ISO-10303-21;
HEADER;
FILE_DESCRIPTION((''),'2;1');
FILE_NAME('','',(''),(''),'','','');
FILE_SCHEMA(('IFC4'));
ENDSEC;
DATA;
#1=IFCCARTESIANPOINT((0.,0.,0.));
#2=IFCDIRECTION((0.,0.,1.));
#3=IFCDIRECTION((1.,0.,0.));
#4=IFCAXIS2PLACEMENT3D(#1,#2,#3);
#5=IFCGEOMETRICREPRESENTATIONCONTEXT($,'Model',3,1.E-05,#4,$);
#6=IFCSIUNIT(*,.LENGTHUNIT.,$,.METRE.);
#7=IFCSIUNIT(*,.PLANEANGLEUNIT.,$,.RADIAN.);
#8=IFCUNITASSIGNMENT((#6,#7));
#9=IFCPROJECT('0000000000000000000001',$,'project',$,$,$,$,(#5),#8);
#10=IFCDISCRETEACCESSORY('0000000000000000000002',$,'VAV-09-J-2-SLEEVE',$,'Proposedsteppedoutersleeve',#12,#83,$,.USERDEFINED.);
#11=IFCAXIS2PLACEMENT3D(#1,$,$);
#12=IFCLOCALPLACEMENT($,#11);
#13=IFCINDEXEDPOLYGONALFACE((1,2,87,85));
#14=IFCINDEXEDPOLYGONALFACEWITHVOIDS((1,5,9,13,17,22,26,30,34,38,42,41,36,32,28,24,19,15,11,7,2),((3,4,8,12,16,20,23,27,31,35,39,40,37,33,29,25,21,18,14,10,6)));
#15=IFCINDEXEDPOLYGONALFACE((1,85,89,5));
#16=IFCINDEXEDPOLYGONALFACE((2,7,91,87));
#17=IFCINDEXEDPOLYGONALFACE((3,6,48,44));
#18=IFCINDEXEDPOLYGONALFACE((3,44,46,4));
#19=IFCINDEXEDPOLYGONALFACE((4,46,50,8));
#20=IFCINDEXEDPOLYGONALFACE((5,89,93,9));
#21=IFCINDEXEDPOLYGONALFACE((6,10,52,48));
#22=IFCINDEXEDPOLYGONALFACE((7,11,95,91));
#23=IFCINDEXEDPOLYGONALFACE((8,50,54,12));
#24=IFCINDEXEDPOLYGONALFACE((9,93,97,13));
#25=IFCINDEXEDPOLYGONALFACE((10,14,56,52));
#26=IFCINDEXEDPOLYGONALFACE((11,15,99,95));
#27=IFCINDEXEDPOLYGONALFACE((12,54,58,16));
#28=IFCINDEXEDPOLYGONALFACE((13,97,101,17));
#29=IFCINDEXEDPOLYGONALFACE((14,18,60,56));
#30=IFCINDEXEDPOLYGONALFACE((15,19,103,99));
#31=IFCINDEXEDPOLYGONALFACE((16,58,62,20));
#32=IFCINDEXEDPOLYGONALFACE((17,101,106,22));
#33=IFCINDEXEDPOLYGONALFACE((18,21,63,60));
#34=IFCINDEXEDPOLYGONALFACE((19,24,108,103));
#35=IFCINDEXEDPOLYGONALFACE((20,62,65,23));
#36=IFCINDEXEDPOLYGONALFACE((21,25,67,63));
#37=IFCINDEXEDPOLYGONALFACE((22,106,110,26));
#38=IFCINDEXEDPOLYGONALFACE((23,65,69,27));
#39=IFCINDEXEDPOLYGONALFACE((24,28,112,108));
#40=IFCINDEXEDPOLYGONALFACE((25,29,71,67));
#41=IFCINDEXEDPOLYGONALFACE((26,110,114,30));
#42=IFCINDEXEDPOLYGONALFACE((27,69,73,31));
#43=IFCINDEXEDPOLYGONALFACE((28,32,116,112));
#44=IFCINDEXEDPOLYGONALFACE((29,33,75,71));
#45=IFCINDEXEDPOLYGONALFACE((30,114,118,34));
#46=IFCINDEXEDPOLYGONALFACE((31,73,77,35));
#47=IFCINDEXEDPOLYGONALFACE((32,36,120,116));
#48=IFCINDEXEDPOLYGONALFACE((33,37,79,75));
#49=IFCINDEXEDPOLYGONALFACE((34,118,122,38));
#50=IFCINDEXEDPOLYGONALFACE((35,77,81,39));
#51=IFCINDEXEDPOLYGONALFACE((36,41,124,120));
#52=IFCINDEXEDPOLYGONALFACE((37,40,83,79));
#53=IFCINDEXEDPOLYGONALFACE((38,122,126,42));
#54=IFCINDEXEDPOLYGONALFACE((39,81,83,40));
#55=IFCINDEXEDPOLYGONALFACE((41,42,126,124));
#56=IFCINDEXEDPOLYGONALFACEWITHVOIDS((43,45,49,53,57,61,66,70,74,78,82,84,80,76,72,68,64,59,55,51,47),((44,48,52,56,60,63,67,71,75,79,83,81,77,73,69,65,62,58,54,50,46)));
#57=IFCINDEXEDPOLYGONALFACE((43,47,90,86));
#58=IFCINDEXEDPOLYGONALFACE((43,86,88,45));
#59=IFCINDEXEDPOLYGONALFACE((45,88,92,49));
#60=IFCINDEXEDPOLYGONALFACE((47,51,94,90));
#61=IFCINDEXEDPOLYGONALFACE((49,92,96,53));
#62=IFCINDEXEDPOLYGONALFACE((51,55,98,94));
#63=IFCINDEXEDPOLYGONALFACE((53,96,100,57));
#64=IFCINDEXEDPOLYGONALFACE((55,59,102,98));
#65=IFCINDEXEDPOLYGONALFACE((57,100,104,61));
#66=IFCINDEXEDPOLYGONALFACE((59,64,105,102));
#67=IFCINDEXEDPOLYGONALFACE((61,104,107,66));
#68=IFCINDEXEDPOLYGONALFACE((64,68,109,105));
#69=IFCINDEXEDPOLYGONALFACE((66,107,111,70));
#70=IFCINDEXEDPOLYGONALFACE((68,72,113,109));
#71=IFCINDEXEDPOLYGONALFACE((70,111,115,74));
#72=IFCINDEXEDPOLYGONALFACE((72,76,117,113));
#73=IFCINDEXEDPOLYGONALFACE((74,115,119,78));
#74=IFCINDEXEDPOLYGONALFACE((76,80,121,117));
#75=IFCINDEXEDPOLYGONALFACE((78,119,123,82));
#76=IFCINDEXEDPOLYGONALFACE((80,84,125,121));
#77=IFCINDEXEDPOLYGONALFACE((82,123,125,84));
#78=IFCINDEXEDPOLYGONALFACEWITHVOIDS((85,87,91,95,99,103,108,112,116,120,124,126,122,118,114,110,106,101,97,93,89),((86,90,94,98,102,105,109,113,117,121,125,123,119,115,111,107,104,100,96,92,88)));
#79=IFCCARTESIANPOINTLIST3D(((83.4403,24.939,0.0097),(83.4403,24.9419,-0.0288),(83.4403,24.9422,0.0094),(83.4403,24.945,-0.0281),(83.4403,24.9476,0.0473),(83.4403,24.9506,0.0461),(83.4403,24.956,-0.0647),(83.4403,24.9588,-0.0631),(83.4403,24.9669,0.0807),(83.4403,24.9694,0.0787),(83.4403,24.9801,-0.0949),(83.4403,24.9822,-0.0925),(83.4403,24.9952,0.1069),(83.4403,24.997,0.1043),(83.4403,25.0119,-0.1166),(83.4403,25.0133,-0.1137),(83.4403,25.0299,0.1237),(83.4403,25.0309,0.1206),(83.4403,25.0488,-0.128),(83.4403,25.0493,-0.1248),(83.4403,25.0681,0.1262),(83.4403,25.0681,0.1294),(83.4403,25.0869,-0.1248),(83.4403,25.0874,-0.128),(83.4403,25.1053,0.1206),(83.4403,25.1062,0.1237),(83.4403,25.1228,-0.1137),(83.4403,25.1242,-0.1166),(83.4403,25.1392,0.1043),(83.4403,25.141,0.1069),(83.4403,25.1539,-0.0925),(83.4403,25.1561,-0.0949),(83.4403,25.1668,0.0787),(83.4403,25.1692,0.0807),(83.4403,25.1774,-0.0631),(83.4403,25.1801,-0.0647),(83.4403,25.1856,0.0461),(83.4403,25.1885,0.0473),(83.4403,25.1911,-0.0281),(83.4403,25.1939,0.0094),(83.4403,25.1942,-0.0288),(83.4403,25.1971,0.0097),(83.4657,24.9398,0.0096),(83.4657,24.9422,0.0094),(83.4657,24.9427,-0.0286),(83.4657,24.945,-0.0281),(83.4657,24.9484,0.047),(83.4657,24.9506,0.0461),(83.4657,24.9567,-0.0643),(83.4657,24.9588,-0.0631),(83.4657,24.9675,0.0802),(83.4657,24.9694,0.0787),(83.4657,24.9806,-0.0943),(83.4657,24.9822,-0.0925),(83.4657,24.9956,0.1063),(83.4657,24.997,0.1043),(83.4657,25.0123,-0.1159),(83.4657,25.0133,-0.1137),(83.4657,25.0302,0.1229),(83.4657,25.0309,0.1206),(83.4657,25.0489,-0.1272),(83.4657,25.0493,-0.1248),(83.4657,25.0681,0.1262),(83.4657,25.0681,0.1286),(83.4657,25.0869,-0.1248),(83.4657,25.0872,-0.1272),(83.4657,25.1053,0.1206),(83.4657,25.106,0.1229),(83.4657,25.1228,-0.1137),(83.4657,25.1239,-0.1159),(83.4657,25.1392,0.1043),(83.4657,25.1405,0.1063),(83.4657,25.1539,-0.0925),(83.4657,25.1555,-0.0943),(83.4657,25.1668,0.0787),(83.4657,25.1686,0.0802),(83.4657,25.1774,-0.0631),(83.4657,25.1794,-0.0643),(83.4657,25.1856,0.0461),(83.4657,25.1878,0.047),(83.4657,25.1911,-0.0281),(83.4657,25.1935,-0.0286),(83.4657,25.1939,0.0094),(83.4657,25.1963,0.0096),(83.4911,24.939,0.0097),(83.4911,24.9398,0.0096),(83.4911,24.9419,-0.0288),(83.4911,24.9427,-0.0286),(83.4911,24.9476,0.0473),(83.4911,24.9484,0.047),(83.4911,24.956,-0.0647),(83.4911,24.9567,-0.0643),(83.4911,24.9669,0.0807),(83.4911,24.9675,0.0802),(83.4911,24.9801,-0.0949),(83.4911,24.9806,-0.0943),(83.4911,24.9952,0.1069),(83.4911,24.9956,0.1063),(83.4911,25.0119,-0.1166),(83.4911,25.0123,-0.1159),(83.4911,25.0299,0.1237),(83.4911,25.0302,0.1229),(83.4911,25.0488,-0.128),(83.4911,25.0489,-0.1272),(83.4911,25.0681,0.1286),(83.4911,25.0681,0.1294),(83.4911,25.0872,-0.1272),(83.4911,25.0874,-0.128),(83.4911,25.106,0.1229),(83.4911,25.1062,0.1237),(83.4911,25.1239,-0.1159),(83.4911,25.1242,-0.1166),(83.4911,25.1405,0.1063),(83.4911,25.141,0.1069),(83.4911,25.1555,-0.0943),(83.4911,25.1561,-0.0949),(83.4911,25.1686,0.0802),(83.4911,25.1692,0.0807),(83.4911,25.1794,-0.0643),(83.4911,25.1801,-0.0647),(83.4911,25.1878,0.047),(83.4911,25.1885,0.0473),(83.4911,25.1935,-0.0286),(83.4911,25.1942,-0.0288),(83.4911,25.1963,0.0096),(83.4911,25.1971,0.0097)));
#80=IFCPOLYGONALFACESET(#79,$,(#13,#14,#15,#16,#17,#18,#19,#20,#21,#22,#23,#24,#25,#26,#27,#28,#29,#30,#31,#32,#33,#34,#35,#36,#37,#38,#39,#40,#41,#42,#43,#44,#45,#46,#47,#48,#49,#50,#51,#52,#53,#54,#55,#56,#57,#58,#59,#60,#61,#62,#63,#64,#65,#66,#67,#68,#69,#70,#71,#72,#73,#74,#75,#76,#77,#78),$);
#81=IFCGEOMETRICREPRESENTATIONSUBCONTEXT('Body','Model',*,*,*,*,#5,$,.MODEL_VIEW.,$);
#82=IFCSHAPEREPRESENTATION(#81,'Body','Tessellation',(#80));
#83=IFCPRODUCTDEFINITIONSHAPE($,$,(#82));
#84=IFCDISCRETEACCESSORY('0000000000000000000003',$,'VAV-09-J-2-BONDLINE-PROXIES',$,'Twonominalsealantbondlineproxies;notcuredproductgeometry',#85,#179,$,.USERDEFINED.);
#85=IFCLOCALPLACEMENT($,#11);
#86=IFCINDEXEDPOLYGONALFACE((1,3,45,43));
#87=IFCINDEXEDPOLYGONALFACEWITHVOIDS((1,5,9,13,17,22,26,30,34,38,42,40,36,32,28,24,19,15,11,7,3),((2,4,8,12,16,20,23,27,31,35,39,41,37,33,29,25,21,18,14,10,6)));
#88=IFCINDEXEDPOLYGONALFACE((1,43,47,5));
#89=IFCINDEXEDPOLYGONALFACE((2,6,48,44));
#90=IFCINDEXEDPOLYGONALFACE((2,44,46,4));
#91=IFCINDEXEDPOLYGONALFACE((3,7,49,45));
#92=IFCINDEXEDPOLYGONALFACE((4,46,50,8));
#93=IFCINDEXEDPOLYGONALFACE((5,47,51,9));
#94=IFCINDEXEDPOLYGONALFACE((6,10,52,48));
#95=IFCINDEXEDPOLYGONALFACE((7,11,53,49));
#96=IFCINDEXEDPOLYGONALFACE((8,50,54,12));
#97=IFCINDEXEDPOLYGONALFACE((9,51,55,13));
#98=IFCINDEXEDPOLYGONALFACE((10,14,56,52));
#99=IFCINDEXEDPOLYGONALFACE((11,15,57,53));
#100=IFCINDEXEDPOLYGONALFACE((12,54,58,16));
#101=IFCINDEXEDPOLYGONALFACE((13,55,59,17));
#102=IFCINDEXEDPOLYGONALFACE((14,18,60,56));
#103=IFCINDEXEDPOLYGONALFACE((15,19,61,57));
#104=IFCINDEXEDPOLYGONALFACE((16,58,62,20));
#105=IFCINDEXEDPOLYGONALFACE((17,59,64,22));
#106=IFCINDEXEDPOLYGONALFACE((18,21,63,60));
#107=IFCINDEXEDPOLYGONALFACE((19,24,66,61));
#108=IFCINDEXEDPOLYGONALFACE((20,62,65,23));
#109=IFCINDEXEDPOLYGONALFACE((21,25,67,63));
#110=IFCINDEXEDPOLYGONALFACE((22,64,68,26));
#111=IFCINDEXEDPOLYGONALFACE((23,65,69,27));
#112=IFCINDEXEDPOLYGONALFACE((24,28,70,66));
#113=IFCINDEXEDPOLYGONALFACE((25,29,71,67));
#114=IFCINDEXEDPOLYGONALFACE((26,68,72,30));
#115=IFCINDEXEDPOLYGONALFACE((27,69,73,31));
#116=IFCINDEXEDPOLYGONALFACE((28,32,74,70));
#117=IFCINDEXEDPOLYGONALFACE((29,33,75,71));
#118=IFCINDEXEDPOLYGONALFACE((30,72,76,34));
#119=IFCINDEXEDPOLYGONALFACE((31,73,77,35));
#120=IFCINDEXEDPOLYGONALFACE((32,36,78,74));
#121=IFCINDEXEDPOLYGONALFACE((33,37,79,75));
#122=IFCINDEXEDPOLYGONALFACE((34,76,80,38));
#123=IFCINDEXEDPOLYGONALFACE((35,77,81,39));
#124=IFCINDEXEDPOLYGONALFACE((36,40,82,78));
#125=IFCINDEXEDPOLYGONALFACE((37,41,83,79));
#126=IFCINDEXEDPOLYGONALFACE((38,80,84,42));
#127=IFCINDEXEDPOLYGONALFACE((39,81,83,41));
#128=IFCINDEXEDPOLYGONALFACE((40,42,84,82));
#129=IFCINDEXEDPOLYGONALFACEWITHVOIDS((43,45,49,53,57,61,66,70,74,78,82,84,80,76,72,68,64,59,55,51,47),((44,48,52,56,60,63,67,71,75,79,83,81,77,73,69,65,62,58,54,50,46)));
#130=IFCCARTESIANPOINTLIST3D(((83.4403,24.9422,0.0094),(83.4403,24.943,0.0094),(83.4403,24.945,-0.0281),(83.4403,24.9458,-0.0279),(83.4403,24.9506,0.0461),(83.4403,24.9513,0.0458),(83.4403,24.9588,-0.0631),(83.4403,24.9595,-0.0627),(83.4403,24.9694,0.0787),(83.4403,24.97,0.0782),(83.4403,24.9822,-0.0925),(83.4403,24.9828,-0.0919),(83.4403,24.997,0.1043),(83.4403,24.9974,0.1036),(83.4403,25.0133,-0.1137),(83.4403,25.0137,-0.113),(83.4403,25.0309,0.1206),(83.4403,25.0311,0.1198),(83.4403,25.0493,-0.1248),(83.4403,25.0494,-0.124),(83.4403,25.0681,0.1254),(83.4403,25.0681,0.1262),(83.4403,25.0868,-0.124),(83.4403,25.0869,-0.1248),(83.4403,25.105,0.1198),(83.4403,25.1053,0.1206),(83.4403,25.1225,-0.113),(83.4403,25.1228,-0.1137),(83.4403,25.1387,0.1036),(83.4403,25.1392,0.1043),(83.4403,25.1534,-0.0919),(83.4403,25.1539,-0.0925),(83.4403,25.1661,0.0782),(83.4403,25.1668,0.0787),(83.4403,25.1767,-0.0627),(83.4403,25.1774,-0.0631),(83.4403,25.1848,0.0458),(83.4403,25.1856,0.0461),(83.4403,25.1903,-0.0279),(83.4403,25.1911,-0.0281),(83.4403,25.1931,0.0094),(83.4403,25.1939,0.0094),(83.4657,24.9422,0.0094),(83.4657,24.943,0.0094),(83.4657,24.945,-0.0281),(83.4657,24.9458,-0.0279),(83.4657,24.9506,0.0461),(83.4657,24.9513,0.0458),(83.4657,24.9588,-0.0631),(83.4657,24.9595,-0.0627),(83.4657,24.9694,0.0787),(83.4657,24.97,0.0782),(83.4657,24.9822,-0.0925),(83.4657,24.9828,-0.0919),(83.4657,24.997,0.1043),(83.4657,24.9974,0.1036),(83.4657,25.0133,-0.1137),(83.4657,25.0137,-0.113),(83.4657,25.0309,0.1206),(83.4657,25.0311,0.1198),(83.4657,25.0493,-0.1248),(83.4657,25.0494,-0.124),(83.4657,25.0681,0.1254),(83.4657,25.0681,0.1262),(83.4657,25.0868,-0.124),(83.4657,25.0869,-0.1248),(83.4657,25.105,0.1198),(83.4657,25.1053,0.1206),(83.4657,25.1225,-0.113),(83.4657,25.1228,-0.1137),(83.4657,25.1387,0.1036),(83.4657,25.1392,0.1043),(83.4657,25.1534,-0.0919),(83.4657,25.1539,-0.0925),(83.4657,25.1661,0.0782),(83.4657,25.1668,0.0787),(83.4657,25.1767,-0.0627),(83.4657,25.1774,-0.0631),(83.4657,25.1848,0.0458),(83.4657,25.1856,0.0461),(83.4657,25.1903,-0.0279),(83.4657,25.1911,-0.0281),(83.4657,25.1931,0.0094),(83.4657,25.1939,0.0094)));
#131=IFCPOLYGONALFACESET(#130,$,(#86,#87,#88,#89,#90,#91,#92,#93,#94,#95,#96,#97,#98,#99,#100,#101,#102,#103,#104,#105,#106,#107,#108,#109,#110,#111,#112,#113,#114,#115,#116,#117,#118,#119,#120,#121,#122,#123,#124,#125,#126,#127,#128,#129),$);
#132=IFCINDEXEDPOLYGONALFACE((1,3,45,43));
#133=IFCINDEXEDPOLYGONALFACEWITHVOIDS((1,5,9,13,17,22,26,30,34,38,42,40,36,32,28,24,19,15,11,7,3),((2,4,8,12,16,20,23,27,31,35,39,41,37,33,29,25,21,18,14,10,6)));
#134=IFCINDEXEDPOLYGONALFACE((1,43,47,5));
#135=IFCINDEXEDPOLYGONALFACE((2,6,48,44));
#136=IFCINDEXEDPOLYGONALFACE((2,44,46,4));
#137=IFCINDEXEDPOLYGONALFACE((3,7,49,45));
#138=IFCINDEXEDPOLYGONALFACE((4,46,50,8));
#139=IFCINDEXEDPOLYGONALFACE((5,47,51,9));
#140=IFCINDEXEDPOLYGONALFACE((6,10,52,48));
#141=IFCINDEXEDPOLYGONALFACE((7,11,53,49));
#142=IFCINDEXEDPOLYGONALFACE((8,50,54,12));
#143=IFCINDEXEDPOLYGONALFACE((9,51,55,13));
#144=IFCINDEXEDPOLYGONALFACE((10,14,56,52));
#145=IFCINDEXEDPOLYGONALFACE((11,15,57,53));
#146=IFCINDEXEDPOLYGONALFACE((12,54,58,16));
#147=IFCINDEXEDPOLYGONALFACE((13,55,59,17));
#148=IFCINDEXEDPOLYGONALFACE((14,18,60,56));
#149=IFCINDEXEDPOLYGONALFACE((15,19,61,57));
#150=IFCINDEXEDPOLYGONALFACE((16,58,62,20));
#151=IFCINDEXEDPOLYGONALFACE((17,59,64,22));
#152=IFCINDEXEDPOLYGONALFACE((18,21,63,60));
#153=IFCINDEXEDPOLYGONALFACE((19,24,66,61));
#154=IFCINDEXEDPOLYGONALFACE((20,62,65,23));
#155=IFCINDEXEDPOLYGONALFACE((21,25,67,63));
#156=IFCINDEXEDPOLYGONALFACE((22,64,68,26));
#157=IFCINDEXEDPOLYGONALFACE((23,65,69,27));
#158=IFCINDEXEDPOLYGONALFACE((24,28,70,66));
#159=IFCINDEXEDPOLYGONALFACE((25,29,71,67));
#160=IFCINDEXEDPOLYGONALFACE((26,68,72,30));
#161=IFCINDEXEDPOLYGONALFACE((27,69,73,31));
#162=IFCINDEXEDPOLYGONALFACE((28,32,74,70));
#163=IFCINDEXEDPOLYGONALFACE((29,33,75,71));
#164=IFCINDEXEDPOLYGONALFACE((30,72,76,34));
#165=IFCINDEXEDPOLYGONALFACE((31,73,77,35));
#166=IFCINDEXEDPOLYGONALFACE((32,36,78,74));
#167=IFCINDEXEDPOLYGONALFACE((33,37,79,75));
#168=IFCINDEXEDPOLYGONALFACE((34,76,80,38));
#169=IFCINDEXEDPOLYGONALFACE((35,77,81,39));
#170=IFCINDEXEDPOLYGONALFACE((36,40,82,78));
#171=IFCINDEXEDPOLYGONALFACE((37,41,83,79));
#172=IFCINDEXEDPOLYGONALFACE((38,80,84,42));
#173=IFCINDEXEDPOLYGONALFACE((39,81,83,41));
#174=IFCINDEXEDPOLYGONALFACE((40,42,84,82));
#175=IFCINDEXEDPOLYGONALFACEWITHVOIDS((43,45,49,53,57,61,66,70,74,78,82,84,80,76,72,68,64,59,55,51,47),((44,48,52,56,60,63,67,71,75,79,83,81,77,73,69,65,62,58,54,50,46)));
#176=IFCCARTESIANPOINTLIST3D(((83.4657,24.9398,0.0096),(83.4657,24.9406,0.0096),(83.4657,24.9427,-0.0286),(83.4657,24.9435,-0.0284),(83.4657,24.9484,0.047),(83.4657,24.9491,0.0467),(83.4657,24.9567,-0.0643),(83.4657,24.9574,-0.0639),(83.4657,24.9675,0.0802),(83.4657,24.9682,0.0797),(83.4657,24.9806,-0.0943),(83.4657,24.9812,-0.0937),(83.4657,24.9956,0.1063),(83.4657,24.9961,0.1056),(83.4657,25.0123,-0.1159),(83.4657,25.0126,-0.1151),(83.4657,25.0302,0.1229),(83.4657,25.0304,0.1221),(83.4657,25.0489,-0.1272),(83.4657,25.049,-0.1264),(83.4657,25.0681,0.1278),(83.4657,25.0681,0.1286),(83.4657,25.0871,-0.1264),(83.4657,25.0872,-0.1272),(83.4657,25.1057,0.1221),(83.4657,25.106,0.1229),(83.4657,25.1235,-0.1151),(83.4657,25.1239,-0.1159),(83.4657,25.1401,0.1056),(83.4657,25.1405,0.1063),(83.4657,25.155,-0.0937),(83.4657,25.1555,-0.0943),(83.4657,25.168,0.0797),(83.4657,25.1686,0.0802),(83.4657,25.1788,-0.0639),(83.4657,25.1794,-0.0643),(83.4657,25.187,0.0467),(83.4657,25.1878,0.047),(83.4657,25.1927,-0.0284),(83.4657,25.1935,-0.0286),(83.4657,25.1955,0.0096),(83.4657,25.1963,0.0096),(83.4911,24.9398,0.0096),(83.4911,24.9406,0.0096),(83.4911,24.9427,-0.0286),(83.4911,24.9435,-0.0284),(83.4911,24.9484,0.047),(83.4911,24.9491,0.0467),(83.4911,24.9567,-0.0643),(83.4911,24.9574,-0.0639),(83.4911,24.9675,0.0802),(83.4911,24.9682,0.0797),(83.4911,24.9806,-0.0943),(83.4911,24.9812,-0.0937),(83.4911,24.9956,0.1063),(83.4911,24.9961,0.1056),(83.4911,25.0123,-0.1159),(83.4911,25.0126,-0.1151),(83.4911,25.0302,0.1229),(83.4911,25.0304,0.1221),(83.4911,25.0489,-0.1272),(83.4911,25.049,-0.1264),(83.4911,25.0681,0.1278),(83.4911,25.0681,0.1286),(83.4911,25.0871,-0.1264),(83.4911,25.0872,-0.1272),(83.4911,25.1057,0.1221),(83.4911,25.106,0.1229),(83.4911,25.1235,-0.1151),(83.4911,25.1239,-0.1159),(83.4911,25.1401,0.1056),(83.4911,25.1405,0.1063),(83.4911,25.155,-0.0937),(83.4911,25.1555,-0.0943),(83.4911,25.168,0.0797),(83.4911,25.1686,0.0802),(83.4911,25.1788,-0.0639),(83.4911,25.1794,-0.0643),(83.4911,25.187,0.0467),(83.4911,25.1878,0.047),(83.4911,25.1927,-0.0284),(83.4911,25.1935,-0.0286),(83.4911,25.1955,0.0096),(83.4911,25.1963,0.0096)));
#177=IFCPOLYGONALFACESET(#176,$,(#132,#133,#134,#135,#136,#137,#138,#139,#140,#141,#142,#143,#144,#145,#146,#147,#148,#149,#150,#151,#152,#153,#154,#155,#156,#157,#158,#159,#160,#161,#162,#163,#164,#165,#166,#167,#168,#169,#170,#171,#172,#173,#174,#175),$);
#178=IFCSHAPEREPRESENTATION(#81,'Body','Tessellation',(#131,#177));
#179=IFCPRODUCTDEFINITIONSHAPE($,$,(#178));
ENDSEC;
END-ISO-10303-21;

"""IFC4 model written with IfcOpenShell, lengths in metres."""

from ifc_helpers import new_model, entity, si_unit, frame, origin_with_axes, place, context, subcontext, project, element, save


model = new_model("IFC4")

# Units and contexts
model_context = context("Model", 3, precision=1e-05, world=origin_with_axes())
body_context = subcontext(model_context, "Body", "Model", "MODEL_VIEW")
ifc_project = project(units=[si_unit("LENGTHUNIT", "METRE"), si_unit("PLANEANGLEUNIT", "RADIAN")], contexts=[model_context])

# Discrete accessories
discrete_accessory_1_placement = place(None, frame((83.4657, 25.0681, 0.0), z_axis=(0.0, 1.0, 0.0), x_axis=(0.0, 0.0, 1.0)))
element("IfcDiscreteAccessory", 1, at=discrete_accessory_1_placement, Name="VAV-09-J-2-SLEEVE", ObjectType="Proposedsteppedoutersleeve", PredefinedType="USERDEFINED", context=body_context, shape_type="SweptSolid", body=[
    entity("IfcRevolvedAreaSolid", entity("IfcArbitraryClosedProfileDef", "AREA", None, entity("IfcPolyline", [entity("IfcCartesianPoint", [0.1262, -0.0254]), entity("IfcCartesianPoint", [0.1294, -0.0254]), entity("IfcCartesianPoint", [0.1294, 0.0254]), entity("IfcCartesianPoint", [0.1286, 0.0254]), entity("IfcCartesianPoint", [0.1286, 0.0]), entity("IfcCartesianPoint", [0.1262, 0.0]), entity("IfcCartesianPoint", [0.1262, -0.0254])])), entity("IfcAxis2Placement3D", entity("IfcCartesianPoint", [0.0, 0.0, 0.0])), entity("IfcAxis1Placement", entity("IfcCartesianPoint", [0.0, 0.0, 0.0]), entity("IfcDirection", [0.0, 1.0, 0.0])), 6.283185),
])
discrete_accessory_2_placement = place(None, frame((83.4657, 25.0681, 0.0), z_axis=(0.0, 1.0, 0.0), x_axis=(0.0, 0.0, 1.0)))
element("IfcDiscreteAccessory", 2, at=discrete_accessory_2_placement, Name="VAV-09-J-2-BONDLINE-PROXIES", ObjectType="Twonominalsealantbondlineproxies;notcuredproductgeometry", PredefinedType="USERDEFINED", context=body_context, shape_type="SweptSolid", body=[
    entity("IfcRevolvedAreaSolid", entity("IfcArbitraryClosedProfileDef", "AREA", None, entity("IfcPolyline", [entity("IfcCartesianPoint", [0.1254, -0.0254]), entity("IfcCartesianPoint", [0.1262, -0.0254]), entity("IfcCartesianPoint", [0.1262, 0.0]), entity("IfcCartesianPoint", [0.1254, 0.0]), entity("IfcCartesianPoint", [0.1254, -0.0254])])), entity("IfcAxis2Placement3D", entity("IfcCartesianPoint", [0.0, 0.0, 0.0])), entity("IfcAxis1Placement", entity("IfcCartesianPoint", [0.0, 0.0, 0.0]), entity("IfcDirection", [0.0, 1.0, 0.0])), 6.283185),
    entity("IfcRevolvedAreaSolid", entity("IfcArbitraryClosedProfileDef", "AREA", None, entity("IfcPolyline", [entity("IfcCartesianPoint", [0.1278, 0.0]), entity("IfcCartesianPoint", [0.1286, 0.0]), entity("IfcCartesianPoint", [0.1286, 0.0254]), entity("IfcCartesianPoint", [0.1278, 0.0254]), entity("IfcCartesianPoint", [0.1278, 0.0])])), entity("IfcAxis2Placement3D", entity("IfcCartesianPoint", [0.0, 0.0, 0.0])), entity("IfcAxis1Placement", entity("IfcCartesianPoint", [0.0, 0.0, 0.0]), entity("IfcDirection", [0.0, 1.0, 0.0])), 6.283185),
])

save(model, "model.ifc")
